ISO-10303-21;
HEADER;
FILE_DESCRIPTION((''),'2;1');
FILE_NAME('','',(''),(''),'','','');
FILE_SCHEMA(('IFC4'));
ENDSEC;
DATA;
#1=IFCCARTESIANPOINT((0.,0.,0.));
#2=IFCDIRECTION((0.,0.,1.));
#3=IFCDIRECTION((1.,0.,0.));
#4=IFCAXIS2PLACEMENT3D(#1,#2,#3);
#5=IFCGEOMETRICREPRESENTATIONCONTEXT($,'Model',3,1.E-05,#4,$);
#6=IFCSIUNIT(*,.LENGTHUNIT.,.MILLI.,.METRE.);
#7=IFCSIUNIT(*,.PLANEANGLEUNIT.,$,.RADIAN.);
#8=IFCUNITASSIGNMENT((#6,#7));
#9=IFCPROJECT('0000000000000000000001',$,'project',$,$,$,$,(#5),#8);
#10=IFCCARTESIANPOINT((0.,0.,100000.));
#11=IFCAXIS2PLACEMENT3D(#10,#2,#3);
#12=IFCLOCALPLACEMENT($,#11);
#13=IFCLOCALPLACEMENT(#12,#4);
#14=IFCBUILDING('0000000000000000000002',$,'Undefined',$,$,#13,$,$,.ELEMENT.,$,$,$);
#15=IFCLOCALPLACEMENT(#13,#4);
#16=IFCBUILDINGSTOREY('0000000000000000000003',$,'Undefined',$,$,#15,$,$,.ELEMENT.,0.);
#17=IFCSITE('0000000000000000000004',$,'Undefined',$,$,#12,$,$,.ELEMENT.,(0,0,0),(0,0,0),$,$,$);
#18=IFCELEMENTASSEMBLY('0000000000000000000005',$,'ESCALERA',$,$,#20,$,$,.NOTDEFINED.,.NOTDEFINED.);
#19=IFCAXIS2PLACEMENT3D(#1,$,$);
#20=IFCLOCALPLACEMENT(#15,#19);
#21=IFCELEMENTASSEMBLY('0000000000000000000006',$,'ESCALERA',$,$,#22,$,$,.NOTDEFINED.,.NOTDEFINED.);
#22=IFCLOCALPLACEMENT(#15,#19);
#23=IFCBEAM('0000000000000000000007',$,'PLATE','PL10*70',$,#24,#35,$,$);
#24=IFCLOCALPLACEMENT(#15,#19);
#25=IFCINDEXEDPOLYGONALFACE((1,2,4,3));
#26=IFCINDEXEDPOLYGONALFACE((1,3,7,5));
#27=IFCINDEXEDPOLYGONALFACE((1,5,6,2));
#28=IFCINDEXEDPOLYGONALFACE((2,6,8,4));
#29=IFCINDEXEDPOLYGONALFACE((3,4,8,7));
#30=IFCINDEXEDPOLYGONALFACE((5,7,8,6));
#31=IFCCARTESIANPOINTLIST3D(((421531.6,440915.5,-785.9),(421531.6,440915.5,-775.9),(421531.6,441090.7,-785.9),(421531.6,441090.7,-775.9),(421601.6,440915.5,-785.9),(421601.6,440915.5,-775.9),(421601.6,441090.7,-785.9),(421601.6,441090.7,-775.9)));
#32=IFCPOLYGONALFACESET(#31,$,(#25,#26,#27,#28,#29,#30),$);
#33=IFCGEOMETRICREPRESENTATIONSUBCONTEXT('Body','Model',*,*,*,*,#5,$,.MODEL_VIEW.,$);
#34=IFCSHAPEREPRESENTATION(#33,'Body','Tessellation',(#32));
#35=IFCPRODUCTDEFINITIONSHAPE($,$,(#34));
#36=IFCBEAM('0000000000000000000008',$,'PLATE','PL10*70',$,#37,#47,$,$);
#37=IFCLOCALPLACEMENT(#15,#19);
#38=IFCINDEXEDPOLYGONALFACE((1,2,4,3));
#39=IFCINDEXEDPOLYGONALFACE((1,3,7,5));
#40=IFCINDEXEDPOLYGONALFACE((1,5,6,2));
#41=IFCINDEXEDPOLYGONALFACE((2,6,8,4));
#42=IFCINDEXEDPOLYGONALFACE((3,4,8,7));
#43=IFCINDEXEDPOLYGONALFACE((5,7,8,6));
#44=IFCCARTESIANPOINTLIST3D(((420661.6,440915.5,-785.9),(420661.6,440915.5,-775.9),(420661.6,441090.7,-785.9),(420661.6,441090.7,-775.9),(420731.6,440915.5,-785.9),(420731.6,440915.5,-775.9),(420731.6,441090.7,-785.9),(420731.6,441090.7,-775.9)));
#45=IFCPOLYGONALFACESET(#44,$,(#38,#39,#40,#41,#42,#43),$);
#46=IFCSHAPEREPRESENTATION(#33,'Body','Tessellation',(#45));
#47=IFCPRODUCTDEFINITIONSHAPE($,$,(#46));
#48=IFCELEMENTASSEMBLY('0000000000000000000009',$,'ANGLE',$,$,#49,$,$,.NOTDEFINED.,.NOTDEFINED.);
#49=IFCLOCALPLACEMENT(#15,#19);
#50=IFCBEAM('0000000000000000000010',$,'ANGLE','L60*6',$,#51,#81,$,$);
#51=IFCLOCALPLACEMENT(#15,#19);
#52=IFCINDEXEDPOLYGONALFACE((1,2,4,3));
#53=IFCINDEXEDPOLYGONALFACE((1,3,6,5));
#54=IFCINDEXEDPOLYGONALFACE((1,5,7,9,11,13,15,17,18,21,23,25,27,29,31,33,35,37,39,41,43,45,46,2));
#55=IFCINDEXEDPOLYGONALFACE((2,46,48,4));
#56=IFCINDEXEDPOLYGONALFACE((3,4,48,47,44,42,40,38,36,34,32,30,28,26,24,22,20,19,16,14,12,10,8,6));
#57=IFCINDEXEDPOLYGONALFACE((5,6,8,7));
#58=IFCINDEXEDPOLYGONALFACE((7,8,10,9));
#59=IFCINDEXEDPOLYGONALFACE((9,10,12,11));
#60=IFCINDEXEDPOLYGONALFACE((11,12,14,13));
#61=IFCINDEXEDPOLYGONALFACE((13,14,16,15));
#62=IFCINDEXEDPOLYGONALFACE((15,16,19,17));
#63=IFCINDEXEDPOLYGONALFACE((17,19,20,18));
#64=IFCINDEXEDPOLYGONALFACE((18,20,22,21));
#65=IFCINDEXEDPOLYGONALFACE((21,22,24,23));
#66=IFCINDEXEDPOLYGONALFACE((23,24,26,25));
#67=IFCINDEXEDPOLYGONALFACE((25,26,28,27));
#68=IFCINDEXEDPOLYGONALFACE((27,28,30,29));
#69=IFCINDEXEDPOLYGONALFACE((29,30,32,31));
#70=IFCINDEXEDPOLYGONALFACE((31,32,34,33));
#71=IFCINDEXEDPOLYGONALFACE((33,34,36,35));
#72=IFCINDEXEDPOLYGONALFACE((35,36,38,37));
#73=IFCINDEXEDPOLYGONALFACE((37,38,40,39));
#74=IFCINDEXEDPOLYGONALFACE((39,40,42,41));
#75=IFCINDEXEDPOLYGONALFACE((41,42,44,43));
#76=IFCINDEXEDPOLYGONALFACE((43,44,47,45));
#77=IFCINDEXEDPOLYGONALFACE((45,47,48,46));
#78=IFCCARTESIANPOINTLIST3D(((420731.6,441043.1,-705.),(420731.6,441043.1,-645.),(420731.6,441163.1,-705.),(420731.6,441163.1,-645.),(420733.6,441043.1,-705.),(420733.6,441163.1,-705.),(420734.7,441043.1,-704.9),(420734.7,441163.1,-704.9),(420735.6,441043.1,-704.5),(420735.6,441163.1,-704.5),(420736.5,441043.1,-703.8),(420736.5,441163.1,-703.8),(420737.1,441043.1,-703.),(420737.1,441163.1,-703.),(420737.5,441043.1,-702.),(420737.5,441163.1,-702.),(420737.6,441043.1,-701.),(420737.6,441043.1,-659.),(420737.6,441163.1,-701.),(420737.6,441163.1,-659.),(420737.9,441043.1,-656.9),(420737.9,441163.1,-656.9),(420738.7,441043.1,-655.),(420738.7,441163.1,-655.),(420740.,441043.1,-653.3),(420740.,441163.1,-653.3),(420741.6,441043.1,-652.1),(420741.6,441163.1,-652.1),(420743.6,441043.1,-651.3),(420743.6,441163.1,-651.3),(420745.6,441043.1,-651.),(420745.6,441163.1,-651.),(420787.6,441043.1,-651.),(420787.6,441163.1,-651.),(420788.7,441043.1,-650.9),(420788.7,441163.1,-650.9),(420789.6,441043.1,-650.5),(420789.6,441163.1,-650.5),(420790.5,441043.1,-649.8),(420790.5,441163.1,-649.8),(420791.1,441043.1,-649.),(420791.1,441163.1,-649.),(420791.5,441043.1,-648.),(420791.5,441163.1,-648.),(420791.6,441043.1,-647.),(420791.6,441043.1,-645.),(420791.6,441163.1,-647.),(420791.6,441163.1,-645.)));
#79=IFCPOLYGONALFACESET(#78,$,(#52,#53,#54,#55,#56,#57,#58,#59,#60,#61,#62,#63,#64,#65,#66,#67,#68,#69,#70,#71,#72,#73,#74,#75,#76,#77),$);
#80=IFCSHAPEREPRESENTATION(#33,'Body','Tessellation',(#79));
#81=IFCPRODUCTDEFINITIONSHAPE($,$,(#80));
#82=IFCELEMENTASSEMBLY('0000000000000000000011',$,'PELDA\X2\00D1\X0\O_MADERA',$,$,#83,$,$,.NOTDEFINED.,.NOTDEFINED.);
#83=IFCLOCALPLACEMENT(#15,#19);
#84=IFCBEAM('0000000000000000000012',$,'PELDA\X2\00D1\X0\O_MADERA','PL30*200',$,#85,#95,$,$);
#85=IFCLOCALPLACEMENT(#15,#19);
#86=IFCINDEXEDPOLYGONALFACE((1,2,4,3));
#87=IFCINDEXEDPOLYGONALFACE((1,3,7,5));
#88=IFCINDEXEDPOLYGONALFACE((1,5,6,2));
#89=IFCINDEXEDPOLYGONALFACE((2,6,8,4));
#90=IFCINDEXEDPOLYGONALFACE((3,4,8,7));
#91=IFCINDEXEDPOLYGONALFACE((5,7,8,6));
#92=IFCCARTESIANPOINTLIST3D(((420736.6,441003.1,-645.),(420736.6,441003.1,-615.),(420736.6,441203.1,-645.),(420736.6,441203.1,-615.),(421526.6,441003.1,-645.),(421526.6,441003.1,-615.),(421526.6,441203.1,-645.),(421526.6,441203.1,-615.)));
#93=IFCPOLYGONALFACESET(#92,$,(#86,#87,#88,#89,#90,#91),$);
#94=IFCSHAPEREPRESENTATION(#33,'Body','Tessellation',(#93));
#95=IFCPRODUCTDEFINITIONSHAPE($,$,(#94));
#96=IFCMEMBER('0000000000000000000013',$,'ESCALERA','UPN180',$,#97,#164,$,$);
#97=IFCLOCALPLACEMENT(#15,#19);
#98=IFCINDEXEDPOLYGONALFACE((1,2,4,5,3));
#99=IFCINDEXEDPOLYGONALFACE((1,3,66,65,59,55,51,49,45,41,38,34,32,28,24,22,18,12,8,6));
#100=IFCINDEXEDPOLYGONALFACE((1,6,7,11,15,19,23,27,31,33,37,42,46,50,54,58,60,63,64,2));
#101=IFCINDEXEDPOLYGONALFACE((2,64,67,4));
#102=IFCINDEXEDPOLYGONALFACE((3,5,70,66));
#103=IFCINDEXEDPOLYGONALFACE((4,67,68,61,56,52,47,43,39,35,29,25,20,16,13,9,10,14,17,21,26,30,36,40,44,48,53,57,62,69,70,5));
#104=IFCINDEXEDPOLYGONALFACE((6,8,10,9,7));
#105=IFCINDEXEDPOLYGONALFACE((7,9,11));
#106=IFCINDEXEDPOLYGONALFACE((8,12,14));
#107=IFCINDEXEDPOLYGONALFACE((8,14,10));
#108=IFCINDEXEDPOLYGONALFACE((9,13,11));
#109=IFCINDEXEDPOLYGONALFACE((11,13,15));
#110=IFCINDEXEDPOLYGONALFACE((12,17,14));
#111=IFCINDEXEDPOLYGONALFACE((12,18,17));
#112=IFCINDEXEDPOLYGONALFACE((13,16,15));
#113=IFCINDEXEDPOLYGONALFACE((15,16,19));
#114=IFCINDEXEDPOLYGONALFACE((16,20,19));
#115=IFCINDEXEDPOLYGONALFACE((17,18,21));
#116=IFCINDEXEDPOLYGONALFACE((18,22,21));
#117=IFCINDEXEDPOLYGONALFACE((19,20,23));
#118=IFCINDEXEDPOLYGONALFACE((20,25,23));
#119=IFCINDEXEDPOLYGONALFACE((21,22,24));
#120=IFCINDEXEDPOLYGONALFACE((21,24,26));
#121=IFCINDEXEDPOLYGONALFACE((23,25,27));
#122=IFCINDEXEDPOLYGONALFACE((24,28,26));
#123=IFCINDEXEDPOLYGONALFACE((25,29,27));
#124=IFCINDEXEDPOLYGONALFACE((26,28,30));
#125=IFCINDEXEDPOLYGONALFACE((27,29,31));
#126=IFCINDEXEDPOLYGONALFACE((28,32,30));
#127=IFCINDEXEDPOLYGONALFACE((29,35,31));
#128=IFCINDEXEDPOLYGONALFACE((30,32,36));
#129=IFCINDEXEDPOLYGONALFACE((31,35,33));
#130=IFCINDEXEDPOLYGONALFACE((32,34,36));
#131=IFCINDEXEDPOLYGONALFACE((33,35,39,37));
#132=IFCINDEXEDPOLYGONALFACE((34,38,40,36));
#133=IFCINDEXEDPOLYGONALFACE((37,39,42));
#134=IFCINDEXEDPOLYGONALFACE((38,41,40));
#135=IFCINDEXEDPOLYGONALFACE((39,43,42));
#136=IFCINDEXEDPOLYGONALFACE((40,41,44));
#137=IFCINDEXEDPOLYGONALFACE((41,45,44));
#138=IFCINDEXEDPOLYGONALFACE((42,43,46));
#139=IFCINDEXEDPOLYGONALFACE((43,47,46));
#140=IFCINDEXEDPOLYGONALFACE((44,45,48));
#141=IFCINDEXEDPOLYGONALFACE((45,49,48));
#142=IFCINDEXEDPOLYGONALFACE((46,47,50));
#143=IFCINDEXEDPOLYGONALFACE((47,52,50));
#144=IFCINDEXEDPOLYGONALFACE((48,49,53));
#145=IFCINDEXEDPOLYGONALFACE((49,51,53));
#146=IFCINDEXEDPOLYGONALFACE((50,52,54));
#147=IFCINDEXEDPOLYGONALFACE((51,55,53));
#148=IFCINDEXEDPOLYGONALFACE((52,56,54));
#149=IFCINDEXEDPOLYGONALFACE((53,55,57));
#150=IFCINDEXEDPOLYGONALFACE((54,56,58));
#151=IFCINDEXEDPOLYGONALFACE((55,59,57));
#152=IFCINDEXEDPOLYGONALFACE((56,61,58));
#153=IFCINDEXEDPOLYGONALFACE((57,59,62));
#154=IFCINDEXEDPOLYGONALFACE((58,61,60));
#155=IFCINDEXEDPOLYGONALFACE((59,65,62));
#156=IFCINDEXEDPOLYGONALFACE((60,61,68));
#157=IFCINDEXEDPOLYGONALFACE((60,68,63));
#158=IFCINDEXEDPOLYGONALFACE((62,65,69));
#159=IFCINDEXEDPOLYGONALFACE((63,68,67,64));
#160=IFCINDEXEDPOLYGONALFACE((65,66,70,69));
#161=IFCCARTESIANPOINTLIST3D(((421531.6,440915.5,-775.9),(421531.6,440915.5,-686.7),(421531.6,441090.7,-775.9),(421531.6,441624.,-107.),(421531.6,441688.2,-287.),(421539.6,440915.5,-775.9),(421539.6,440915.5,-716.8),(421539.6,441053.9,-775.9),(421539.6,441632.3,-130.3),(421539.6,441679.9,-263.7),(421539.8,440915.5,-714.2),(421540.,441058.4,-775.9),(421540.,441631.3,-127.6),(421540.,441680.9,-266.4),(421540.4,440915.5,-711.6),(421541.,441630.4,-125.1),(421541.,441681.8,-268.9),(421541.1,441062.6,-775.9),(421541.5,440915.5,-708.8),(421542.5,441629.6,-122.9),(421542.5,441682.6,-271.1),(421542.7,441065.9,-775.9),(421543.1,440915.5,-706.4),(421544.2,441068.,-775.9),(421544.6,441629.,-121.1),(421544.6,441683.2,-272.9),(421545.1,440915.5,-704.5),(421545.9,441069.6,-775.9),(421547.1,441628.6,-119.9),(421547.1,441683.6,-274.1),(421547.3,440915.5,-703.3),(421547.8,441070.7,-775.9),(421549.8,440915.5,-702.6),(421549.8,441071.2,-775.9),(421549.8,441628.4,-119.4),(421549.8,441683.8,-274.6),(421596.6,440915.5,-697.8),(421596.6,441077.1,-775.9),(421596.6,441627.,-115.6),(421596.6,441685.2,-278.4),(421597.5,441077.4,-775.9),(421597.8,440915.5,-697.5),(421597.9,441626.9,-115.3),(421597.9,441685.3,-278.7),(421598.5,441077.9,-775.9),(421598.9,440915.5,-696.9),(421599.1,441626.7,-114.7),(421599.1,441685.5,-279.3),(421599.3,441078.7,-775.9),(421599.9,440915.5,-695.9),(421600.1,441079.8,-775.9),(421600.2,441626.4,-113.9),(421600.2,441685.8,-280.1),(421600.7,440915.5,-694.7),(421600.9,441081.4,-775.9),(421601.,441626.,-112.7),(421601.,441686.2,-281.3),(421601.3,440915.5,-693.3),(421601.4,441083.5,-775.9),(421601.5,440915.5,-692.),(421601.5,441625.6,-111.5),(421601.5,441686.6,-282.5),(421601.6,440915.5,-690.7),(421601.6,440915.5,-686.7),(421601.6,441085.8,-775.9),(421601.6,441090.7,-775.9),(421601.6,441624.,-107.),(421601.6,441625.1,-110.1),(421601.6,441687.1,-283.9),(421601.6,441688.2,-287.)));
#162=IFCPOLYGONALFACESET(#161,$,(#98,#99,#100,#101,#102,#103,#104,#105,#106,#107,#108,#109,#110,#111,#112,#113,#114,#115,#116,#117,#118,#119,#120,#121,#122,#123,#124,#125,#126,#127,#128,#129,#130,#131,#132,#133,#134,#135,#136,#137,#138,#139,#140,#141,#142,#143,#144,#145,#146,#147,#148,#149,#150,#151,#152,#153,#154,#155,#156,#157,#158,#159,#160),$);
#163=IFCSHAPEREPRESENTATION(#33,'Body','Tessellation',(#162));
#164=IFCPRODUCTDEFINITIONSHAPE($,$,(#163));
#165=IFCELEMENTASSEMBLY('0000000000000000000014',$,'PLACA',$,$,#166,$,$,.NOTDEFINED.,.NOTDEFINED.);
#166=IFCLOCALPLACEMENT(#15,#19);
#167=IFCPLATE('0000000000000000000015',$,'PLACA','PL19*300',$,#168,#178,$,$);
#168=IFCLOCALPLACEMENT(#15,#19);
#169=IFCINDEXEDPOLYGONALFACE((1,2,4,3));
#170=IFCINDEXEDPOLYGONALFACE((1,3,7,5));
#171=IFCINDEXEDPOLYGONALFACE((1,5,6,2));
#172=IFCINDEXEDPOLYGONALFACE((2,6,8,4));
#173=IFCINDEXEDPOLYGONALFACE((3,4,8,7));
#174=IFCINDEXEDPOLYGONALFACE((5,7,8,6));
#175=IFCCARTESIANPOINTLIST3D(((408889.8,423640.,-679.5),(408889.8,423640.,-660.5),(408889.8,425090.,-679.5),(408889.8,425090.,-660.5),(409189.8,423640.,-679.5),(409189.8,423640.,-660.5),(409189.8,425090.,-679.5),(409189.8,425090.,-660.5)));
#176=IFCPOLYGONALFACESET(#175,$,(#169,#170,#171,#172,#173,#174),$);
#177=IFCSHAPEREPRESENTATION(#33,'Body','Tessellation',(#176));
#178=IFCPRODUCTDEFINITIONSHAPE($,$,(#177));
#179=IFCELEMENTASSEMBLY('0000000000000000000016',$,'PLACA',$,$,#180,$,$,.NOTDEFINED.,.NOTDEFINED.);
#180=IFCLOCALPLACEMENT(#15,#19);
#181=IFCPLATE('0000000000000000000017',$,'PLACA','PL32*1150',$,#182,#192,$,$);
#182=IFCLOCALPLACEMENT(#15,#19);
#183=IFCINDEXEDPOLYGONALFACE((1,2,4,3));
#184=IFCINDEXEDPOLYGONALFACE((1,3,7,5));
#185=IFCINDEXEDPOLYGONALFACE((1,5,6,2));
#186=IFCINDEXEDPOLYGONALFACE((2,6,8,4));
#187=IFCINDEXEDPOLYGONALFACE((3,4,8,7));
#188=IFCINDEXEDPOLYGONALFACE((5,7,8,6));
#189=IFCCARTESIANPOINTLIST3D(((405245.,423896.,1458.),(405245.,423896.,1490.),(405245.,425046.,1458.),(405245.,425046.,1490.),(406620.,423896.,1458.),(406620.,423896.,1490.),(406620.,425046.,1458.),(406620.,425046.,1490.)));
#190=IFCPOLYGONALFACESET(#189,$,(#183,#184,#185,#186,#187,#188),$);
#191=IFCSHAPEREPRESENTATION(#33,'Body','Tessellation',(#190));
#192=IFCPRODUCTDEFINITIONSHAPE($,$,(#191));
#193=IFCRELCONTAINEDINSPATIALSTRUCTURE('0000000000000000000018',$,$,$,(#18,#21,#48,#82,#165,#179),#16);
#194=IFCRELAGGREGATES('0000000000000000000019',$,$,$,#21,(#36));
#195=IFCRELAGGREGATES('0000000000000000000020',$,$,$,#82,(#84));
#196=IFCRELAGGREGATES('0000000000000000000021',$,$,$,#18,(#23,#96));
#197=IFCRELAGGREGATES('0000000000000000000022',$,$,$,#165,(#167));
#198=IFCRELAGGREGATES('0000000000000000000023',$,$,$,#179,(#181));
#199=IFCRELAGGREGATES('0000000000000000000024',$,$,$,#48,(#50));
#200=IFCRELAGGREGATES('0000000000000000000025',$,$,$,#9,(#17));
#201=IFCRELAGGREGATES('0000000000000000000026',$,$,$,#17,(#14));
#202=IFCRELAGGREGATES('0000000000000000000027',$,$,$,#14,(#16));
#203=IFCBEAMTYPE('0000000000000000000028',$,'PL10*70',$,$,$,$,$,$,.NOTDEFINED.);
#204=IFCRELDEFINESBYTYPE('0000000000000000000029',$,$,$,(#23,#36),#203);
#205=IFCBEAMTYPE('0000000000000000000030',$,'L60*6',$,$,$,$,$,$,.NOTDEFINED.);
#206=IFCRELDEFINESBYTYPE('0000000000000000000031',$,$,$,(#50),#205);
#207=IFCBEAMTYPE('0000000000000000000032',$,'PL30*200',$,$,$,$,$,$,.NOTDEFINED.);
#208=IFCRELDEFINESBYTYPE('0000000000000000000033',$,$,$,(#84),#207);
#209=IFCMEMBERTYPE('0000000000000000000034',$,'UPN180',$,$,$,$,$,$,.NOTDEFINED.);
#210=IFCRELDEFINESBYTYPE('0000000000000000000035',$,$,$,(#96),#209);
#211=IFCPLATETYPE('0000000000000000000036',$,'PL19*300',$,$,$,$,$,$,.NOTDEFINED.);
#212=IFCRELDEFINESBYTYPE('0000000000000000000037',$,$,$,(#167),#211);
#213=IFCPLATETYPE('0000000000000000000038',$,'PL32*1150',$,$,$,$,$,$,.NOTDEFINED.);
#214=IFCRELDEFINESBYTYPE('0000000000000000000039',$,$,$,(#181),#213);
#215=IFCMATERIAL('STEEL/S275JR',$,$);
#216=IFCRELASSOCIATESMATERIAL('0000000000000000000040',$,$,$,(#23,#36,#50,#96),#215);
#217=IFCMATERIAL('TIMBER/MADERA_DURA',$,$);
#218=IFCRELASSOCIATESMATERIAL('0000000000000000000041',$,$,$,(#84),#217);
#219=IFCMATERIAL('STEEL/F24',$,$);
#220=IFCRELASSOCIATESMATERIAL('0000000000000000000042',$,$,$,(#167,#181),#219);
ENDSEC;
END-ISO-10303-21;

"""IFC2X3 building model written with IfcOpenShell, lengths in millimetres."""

from ifc_helpers import new_model, si_unit, frame, origin_with_axes, origin_2d_with_axis, place, context, subcontext, project, spatial, polyline, rectangle, l_section, u_section, outline, extrude, clip, halfspace, material, type_object, element, aggregate, save


model = new_model("IFC2X3")

# Units and contexts
model_context = context("Model", 3, precision=1e-05, world=origin_with_axes())
body_context = subcontext(model_context, "Body", "Model", "MODEL_VIEW")
ifc_project = project(units=[si_unit("LENGTHUNIT", "METRE", prefix="MILLI"), si_unit("PLANEANGLEUNIT", "RADIAN")], contexts=[model_context])

# Site, building, storey
site_placement = place(None, frame((0.0, 0.0, 100000.0), z_axis=(0.0, 0.0, 1.0), x_axis=(1.0, 0.0, 0.0)))
site = spatial("IfcSite", under=ifc_project, at=site_placement, Name="Undefined", CompositionType="ELEMENT", RefLatitude=(0, 0, 0), RefLongitude=(0, 0, 0))
building_placement = place(site_placement, origin_with_axes())
building = spatial("IfcBuilding", under=site, at=building_placement, Name="Undefined", CompositionType="ELEMENT")
storey_placement = place(building_placement, origin_with_axes())
storey = spatial("IfcBuildingStorey", under=building, at=storey_placement, Name="Undefined", CompositionType="ELEMENT", Elevation=0.0)

# Shared definitions
ifc_material_1 = material(Name="STEEL/F24")

# Element assemblies
assembly_1_placement = place(storey_placement, origin_with_axes())
assembly_1 = element("IfcElementAssembly", 1, at=assembly_1_placement, inside=storey, Name="ESCALERA", AssemblyPlace="NOTDEFINED", PredefinedType="NOTDEFINED")
ifc_material_2 = material(Name="STEEL/S275JR")
assembly_2_placement = place(storey_placement, origin_with_axes())
assembly_2 = element("IfcElementAssembly", 2, at=assembly_2_placement, inside=storey, Name="ESCALERA", AssemblyPlace="NOTDEFINED", PredefinedType="NOTDEFINED")

# Beams
beam_type_1 = type_object("IfcBeamType", Name="PL10*70", PredefinedType="NOTDEFINED")
beam_1_placement = place(assembly_1_placement, frame((421566.6, 441090.7, -780.9), z_axis=(1.0, -0.000001, 0.0), x_axis=(-0.000001, -1.0, 0.0)))
beam_1 = element("IfcBeam", 3, at=beam_1_placement, type_object=beam_type_1, material=ifc_material_2, Name="PLATE", Description="PL10*70", context=body_context, shape_type="SweptSolid", body=[
    extrude(rectangle(XDim=10.0, YDim=70.0, at=origin_2d_with_axis()), frame((175.3, 0.0, 0.0), z_axis=(-1.0, 0.0, 0.0), x_axis=(0.0, -1.0, 0.0)), (0.0, 0.0, 1.0), 175.2),
])
beam_2_placement = place(assembly_2_placement, frame((420696.6, 441090.7, -780.9), z_axis=(1.0, -0.000001, 0.0), x_axis=(-0.000001, -1.0, 0.0)))
beam_2 = element("IfcBeam", 4, at=beam_2_placement, type_object=beam_type_1, material=ifc_material_2, Name="PLATE", Description="PL10*70", context=body_context, shape_type="SweptSolid", body=[
    extrude(rectangle(XDim=10.0, YDim=70.0, at=origin_2d_with_axis()), frame((175.3, 0.0, 0.0), z_axis=(-1.0, 0.0, 0.0), x_axis=(0.0, -1.0, 0.0)), (0.0, 0.0, 1.0), 175.2),
])
aggregate(assembly_2, [beam_2])

# Element assemblies, beams
assembly_3_placement = place(storey_placement, origin_with_axes())
assembly_3 = element("IfcElementAssembly", 5, at=assembly_3_placement, inside=storey, Name="ANGLE", AssemblyPlace="NOTDEFINED", PredefinedType="NOTDEFINED")
beam_type_2 = type_object("IfcBeamType", Name="L60*6", PredefinedType="NOTDEFINED")
beam_3_placement = place(assembly_3_placement, frame((420761.6, 441043.1, -675.0), z_axis=(1.0, -0.000001, 0.0), x_axis=(0.000001, 1.0, 0.0)))
beam_3 = element("IfcBeam", 6, at=beam_3_placement, type_object=beam_type_2, material=ifc_material_2, Name="ANGLE", Description="L60*6", context=body_context, shape_type="SweptSolid", body=[
    extrude(l_section(Depth=60.0, Width=60.0, Thickness=6.0, FilletRadius=8.0, EdgeRadius=4.0, at=origin_2d_with_axis()), frame((120.0, 0.0, 0.0), z_axis=(-1.0, 0.0, 0.0), x_axis=(0.0, -1.0, 0.0)), (0.0, 0.0, 1.0), 120.0),
])
assembly_4_placement = place(storey_placement, origin_with_axes())
assembly_4 = element("IfcElementAssembly", 7, at=assembly_4_placement, inside=storey, Name="PELDAÑO_MADERA", AssemblyPlace="NOTDEFINED", PredefinedType="NOTDEFINED")
ifc_material_3 = material(Name="TIMBER/MADERA_DURA")
beam_type_3 = type_object("IfcBeamType", Name="PL30*200", PredefinedType="NOTDEFINED")
beam_4_placement = place(assembly_4_placement, frame((421526.6, 441103.1, -630.0), z_axis=(0.000001, 1.0, 0.0), x_axis=(-1.0, 0.000001, 0.0)))
beam_4 = element("IfcBeam", 8, at=beam_4_placement, type_object=beam_type_3, material=ifc_material_3, Name="PELDAÑO_MADERA", Description="PL30*200", context=body_context, shape_type="SweptSolid", body=[
    extrude(rectangle(XDim=30.0, YDim=200.0, at=origin_2d_with_axis()), frame((790.0, 0.0, 0.0), z_axis=(-1.0, 0.0, 0.0), x_axis=(0.0, -1.0, 0.0)), (0.0, 0.0, 1.0), 790.0),
])
aggregate(assembly_4, [beam_4])

# Member
member_type_1 = type_object("IfcMemberType", Name="UPN180", PredefinedType="NOTDEFINED")
member_1_placement = place(assembly_1_placement, frame((421566.6, 441060.1, -684.7), z_axis=(-0.000001, -0.633238, 0.773957), x_axis=(0.000001, 0.773957, 0.633238)))
member_1 = element("IfcMember", 9, at=member_1_placement, type_object=member_type_1, material=ifc_material_2, Name="ESCALERA", Description="UPN180", context=body_context, shape_type="Clipping", body=[
    clip(clip(clip(extrude(u_section(Depth=180.0, FlangeWidth=70.0, WebThickness=8.0, FlangeThickness=11.0, FilletRadius=11.0, EdgeRadius=5.5, FlangeSlope=0.07983, at=origin_2d_with_axis()), frame((878.7, 0.0, 0.0), z_axis=(-1.0, 0.0, 0.0), x_axis=(0.0, -1.0, 0.0)), (0.0, 0.0, 1.0), 1131.3), halfspace(frame((-260.5, 35.0, -90.0), z_axis=(-0.773957, 0.0, 0.633238), x_axis=(0.633238, 0.0, 0.773957)), False)), halfspace(frame((802.2, -35.0, 90.0), z_axis=(-0.941795, 0.0, 0.336186), x_axis=(0.0, -1.0, 0.0)), True)), halfspace(frame((-92.3, -1035.0, -42.3), z_axis=(0.633238, 0.0, 0.773957), x_axis=(-0.773957, 0.0, 0.633238)), True)),
])
aggregate(assembly_1, [beam_1, member_1])

# Element assemblies, plates
assembly_5_placement = place(storey_placement, origin_with_axes())
assembly_5 = element("IfcElementAssembly", 10, at=assembly_5_placement, inside=storey, Name="PLACA", AssemblyPlace="NOTDEFINED", PredefinedType="NOTDEFINED")
plate_type_1 = type_object("IfcPlateType", Name="PL19*300", PredefinedType="NOTDEFINED")
plate_1_placement = place(assembly_5_placement, frame((408889.8, 425090.0, -670.0), z_axis=(0.0, 0.0, 1.0), x_axis=(0.0, -1.0, 0.0)))
plate_1 = element("IfcPlate", 11, at=plate_1_placement, type_object=plate_type_1, material=ifc_material_1, Name="PLACA", Description="PL19*300", context=body_context, shape_type="SweptSolid", body=[
    extrude(outline(polyline([(0.0, 0.0), (1450.0, 0.0), (1450.0, 300.0), (0.0, 300.0), (0.0, 0.0)])), frame((0.0, 0.0, -9.5), z_axis=(0.0, 0.0, 1.0), x_axis=(1.0, 0.0, 0.0)), (0.0, 0.0, 1.0), 19.0),
])
aggregate(assembly_5, [plate_1])
assembly_6_placement = place(storey_placement, origin_with_axes())
assembly_6 = element("IfcElementAssembly", 12, at=assembly_6_placement, inside=storey, Name="PLACA", AssemblyPlace="NOTDEFINED", PredefinedType="NOTDEFINED")
plate_type_2 = type_object("IfcPlateType", Name="PL32*1150", PredefinedType="NOTDEFINED")
plate_2_placement = place(assembly_6_placement, frame((405245.0, 425046.0, 1474.0), z_axis=(0.0, 0.0, 1.0), x_axis=(0.0, -1.0, 0.0)))
plate_2 = element("IfcPlate", 13, at=plate_2_placement, type_object=plate_type_2, material=ifc_material_1, Name="PLACA", Description="PL32*1150", context=body_context, shape_type="SweptSolid", body=[
    extrude(outline(polyline([(0.0, 0.0), (1150.0, 0.0), (1150.0, 1375.0), (0.0, 1375.0), (0.0, 0.0)])), frame((0.0, 0.0, -16.0), z_axis=(0.0, 0.0, 1.0), x_axis=(1.0, 0.0, 0.0)), (0.0, 0.0, 1.0), 32.0),
])
aggregate(assembly_6, [plate_2])

aggregate(assembly_3, [beam_3])

save(model, "model.ifc")
